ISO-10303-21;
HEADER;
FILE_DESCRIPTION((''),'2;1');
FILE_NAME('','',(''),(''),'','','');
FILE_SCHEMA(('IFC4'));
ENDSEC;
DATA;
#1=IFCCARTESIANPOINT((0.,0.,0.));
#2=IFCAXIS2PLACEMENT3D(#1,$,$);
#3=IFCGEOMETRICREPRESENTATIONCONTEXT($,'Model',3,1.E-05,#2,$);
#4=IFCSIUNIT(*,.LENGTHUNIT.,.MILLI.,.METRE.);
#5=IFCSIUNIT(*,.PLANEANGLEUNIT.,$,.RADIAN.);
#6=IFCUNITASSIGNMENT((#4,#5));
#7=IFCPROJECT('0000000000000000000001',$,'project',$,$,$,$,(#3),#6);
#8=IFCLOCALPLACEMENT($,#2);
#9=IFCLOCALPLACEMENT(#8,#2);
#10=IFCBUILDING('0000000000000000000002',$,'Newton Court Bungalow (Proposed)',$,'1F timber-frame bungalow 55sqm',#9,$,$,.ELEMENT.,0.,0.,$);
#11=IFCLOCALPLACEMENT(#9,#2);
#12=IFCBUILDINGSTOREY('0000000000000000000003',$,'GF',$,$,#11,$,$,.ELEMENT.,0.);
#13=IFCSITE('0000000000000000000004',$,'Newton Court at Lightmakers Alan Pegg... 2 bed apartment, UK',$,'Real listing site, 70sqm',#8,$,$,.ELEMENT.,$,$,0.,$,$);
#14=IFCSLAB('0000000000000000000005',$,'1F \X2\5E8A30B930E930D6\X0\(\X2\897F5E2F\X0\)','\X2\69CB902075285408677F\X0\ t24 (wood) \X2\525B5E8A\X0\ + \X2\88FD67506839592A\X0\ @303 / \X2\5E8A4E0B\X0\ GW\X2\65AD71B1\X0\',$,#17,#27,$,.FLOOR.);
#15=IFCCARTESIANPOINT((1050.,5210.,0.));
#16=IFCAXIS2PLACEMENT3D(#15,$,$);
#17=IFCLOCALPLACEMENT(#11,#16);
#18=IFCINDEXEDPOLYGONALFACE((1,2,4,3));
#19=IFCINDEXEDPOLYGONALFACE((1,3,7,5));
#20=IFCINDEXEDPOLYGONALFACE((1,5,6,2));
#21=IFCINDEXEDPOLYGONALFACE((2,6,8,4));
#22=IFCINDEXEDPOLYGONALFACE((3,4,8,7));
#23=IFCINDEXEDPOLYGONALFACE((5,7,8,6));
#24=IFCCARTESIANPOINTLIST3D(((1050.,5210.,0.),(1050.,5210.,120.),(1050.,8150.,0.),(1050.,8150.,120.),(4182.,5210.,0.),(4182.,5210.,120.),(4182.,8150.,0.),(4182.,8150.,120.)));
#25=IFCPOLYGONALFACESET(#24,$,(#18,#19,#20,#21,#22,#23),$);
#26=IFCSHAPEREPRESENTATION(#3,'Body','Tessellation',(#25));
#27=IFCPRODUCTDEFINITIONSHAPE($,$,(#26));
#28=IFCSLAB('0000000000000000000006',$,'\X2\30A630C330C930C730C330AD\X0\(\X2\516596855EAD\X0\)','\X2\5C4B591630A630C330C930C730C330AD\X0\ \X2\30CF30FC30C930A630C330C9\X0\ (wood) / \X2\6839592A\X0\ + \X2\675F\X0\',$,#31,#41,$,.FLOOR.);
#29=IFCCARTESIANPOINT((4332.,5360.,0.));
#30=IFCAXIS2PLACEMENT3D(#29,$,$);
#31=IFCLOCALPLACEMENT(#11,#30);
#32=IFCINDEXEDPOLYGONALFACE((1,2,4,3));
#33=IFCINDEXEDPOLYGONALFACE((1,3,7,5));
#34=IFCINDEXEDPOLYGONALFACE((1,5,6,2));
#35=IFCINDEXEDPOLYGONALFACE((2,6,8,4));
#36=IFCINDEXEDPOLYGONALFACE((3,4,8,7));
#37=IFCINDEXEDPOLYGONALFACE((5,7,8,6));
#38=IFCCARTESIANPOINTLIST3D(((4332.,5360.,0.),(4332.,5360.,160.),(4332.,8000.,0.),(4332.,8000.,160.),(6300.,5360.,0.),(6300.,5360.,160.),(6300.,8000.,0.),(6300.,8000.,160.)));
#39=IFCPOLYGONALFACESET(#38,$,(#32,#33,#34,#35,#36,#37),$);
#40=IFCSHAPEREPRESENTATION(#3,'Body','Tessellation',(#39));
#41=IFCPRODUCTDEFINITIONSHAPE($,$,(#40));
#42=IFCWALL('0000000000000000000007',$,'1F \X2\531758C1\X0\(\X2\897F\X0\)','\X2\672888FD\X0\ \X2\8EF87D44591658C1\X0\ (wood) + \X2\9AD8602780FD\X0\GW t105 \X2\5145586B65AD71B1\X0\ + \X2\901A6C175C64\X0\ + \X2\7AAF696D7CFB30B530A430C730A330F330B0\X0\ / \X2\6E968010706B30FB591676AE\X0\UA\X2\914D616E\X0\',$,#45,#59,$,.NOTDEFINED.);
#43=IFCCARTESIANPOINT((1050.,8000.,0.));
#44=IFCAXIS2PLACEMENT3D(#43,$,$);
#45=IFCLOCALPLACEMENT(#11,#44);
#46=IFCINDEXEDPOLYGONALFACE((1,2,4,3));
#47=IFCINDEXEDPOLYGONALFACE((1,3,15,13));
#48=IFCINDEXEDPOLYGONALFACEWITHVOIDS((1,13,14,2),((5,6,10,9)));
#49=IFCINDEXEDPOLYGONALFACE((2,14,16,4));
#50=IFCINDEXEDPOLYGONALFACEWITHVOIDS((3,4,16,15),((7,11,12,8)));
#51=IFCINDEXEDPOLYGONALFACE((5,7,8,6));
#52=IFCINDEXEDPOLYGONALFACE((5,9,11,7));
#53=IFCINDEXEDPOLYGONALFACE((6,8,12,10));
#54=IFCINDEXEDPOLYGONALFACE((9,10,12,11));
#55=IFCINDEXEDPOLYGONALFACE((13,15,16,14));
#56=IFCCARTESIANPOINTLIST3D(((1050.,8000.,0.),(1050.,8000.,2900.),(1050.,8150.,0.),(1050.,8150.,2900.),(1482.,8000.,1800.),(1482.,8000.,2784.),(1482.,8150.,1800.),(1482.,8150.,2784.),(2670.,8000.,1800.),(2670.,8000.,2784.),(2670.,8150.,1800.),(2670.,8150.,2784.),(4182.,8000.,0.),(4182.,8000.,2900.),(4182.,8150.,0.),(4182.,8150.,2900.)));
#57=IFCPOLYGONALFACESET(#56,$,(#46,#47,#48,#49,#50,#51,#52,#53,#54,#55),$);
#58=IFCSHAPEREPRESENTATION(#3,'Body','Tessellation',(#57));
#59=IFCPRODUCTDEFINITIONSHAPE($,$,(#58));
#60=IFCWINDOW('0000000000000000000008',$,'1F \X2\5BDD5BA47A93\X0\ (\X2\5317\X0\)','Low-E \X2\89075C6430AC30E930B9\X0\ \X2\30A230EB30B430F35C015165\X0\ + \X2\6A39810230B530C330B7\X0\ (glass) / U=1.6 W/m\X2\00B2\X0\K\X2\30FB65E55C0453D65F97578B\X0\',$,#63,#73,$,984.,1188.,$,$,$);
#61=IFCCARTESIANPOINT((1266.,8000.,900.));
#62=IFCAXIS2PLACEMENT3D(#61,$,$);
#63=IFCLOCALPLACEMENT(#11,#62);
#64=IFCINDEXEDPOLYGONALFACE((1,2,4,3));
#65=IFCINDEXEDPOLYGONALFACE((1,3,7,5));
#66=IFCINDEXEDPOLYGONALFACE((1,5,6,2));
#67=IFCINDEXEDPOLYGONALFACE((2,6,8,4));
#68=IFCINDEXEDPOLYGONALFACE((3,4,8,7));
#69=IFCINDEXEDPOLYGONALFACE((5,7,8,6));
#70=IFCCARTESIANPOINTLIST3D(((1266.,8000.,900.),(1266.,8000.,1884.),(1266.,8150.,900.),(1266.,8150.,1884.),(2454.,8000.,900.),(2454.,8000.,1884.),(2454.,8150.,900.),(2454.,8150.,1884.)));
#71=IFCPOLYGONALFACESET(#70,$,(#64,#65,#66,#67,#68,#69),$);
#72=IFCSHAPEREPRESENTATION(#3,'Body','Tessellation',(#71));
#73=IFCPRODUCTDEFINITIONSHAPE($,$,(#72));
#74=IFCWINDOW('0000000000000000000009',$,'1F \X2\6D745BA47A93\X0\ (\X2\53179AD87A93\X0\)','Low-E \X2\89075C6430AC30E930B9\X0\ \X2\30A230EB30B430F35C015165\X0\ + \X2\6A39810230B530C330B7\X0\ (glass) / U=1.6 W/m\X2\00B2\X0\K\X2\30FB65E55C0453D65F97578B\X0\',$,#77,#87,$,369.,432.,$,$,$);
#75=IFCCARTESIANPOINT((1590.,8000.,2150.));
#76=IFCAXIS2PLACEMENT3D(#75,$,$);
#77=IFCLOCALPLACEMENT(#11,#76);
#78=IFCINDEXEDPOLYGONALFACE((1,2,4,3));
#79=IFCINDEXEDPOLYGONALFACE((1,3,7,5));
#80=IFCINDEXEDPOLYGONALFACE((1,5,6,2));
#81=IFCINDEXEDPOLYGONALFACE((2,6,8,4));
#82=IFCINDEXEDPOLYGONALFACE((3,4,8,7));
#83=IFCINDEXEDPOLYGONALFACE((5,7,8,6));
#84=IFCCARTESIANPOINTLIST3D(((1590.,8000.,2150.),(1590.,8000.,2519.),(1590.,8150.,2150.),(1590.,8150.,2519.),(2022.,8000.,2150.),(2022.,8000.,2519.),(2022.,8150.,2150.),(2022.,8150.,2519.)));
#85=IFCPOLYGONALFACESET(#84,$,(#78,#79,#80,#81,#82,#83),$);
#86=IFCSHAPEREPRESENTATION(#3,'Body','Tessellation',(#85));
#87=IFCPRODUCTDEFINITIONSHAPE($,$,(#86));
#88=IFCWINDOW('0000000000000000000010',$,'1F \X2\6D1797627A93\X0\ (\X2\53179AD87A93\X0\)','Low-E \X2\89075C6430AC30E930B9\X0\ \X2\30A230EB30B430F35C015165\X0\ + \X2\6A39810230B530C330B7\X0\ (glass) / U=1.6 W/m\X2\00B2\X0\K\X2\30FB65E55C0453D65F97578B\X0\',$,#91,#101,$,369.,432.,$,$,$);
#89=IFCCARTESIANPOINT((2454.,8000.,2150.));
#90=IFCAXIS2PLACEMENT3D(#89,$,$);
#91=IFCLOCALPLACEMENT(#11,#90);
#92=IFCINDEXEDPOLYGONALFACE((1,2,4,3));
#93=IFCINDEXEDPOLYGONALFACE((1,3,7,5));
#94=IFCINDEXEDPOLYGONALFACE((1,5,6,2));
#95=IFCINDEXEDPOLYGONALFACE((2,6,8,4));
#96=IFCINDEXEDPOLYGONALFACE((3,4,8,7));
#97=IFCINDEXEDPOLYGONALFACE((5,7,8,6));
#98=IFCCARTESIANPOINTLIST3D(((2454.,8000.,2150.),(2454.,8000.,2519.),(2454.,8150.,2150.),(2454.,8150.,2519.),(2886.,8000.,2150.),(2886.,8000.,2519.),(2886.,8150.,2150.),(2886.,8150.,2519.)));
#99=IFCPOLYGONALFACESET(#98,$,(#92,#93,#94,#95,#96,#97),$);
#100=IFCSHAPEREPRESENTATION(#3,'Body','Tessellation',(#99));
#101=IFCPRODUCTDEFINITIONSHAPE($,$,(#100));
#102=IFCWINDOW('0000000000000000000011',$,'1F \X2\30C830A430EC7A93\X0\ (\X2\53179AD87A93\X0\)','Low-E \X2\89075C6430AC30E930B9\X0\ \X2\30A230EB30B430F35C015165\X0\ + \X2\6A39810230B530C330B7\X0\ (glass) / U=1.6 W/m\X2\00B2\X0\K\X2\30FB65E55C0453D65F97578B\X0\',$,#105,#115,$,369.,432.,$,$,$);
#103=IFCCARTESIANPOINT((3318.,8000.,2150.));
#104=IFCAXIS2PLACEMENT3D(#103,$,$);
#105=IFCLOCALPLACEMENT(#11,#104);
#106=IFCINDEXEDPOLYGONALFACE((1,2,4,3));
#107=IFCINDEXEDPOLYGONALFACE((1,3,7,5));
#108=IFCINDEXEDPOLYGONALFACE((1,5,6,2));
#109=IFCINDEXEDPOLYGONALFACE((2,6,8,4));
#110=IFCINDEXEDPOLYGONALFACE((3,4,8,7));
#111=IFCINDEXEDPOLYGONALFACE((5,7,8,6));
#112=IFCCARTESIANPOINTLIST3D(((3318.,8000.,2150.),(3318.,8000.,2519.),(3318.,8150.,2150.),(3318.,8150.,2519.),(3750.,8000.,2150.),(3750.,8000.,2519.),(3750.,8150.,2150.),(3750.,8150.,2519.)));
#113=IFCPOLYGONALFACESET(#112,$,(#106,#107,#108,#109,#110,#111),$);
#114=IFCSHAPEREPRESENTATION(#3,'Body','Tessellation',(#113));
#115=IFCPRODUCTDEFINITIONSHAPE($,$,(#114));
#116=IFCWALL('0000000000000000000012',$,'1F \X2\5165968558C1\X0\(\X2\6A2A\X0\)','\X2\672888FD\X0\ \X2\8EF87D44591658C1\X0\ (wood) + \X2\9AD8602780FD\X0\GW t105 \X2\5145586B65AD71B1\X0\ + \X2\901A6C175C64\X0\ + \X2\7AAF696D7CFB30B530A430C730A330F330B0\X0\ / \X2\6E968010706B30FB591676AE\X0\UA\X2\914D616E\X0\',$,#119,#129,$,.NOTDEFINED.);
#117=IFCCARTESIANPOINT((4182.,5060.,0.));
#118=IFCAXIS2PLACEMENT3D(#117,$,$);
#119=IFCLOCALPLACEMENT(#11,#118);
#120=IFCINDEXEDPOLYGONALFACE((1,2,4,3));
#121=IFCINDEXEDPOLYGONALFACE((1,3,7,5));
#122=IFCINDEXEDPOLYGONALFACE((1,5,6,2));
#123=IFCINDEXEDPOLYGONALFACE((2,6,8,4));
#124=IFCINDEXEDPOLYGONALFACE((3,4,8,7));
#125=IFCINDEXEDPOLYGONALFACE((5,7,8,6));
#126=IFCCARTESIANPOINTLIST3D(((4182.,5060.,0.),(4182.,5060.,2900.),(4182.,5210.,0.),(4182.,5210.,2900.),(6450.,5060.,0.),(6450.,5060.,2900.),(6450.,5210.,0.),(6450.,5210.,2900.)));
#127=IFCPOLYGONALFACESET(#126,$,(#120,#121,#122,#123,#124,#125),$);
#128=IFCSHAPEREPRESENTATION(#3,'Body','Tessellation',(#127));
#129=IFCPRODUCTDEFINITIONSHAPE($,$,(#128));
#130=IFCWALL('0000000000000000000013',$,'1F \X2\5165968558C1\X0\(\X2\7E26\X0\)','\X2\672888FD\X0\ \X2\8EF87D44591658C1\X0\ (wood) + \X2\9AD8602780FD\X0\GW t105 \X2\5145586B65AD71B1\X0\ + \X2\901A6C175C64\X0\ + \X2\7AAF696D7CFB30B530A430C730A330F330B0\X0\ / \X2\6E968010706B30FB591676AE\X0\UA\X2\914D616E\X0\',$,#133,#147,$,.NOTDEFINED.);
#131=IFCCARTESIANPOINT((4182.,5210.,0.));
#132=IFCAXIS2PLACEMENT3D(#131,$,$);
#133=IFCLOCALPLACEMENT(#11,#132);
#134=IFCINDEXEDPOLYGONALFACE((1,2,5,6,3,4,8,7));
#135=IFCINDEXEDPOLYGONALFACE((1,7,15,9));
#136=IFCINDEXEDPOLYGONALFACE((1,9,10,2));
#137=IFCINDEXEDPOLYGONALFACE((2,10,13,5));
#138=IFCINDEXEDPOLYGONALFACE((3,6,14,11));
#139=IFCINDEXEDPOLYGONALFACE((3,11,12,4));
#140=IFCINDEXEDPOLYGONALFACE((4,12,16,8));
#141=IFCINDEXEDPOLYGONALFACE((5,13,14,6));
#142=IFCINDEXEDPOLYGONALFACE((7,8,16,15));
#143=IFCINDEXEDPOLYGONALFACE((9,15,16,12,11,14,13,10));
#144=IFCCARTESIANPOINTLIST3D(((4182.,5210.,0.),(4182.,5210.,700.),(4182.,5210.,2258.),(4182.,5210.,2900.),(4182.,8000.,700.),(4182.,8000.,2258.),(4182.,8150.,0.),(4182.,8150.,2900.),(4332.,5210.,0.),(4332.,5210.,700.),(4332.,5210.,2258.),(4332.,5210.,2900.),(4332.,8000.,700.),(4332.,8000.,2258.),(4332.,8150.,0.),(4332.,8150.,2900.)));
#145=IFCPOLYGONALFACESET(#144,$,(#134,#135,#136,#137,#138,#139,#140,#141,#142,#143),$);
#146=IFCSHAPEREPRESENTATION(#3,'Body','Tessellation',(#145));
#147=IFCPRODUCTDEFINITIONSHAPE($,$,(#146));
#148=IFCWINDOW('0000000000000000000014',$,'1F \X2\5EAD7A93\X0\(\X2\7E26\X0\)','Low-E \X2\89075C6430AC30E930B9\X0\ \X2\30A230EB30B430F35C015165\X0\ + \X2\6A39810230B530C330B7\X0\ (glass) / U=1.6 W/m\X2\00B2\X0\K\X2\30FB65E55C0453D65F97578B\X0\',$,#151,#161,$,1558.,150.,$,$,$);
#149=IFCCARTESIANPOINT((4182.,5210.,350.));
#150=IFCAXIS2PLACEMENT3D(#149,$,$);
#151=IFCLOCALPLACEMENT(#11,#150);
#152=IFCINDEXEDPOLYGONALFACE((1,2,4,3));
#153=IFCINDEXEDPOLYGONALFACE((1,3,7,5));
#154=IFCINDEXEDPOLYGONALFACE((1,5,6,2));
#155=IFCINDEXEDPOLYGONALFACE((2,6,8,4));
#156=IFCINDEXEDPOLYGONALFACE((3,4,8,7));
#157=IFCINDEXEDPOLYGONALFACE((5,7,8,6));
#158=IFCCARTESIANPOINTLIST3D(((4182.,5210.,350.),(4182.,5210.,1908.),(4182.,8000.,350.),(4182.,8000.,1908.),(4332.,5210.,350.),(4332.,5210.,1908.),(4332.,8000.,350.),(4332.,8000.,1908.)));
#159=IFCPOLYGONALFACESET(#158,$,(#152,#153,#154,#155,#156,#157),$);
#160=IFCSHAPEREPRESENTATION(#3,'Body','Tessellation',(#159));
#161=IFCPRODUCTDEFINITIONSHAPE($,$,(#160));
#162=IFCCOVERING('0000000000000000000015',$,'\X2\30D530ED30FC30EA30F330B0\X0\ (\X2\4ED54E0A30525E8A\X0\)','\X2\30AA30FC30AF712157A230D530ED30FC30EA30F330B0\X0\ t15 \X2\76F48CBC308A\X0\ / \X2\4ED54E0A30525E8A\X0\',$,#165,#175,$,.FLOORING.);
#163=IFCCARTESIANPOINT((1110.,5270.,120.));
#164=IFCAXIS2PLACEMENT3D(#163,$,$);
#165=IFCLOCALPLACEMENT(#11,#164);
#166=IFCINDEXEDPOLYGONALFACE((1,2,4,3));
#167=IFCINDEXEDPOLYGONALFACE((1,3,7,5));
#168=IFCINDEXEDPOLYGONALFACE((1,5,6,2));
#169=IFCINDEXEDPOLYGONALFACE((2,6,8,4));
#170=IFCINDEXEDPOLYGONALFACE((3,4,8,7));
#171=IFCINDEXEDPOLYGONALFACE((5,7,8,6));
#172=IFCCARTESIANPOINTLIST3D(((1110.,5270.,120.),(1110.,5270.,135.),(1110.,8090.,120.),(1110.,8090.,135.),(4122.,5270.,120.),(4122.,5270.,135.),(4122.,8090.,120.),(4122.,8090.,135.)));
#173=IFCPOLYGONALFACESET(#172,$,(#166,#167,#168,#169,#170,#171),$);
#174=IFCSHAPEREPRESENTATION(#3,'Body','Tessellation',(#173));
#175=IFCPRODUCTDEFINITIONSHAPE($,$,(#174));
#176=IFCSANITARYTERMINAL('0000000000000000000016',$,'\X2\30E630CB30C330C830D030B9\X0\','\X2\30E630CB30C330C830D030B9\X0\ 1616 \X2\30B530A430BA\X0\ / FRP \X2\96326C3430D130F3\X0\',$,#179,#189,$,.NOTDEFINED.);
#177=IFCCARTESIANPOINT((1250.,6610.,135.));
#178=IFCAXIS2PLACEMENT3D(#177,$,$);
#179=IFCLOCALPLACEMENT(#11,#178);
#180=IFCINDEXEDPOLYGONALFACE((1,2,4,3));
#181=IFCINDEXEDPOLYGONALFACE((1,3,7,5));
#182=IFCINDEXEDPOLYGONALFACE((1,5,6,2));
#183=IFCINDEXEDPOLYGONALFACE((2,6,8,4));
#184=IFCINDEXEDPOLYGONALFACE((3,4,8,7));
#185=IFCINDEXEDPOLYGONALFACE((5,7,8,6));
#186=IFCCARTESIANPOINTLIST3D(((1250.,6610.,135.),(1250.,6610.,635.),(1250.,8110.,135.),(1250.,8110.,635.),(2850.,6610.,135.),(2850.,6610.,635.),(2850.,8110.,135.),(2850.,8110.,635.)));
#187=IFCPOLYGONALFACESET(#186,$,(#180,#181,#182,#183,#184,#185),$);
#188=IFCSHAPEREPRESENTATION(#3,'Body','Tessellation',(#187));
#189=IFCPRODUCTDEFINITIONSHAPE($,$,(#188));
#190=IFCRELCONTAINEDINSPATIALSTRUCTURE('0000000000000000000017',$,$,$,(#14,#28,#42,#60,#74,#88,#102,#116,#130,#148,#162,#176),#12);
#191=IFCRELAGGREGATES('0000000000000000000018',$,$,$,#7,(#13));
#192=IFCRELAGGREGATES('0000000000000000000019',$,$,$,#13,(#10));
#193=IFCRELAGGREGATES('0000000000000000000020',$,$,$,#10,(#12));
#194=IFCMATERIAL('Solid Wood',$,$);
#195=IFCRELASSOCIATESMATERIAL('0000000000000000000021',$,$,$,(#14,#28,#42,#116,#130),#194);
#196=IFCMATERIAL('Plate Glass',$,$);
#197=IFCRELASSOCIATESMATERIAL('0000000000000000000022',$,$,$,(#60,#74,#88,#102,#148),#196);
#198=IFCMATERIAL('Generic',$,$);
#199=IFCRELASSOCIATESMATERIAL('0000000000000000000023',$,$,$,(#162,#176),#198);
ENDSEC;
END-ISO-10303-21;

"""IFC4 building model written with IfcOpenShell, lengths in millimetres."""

from ifc_helpers import new_model, si_unit, frame, frame_2d, origin, place, context, project, spatial, rectangle, extrude, material, element, fill, save


model = new_model("IFC4")

# Units and contexts
model_context = context("Model", 3, precision=1e-05, world=origin())
ifc_project = project(units=[si_unit("LENGTHUNIT", "METRE", prefix="MILLI"), si_unit("PLANEANGLEUNIT", "RADIAN")], contexts=[model_context])

# Site, building, storey
site_placement = place(None, origin())
site = spatial("IfcSite", under=ifc_project, at=site_placement, Name="Newton Court at Lightmakers Alan Pegg... 2 bed apartment, UK", ObjectType="Real listing site, 70sqm", CompositionType="ELEMENT", RefElevation=0.0)
building_placement = place(site_placement, origin())
building = spatial("IfcBuilding", under=site, at=building_placement, Name="Newton Court Bungalow (Proposed)", ObjectType="1F timber-frame bungalow 55sqm", CompositionType="ELEMENT", ElevationOfRefHeight=0.0, ElevationOfTerrain=0.0)
storey_placement = place(building_placement, origin())
storey = spatial("IfcBuildingStorey", under=building, at=storey_placement, Name="GF", CompositionType="ELEMENT", Elevation=0.0)

# Slabs
ifc_material_1 = material(Name="Solid Wood")
slab_1_placement = place(storey_placement, frame((1050.0, 5210.0, 0.0)))
element("IfcSlab", 1, at=slab_1_placement, inside=storey, material=ifc_material_1, Name="1F 床スラブ(西帯)", Description="構造用合板 t24 (wood) 剛床 + 製材根太 @303 / 床下 GW断熱", PredefinedType="FLOOR", context=model_context, shape_type="SweptSolid", body=[
    extrude(rectangle(XDim=3132.0, YDim=2940.0, at=frame_2d((1566.0, 1470.0))), frame((1050.0, 5210.0, 0.0)), (0.0, 0.0, 1.0), 120.0),
])
slab_2_placement = place(storey_placement, frame((4332.0, 5360.0, 0.0)))
element("IfcSlab", 2, at=slab_2_placement, inside=storey, material=ifc_material_1, Name="ウッドデッキ(入隅庭)", Description="屋外ウッドデッキ ハードウッド (wood) / 根太 + 束", PredefinedType="FLOOR", context=model_context, shape_type="SweptSolid", body=[
    extrude(rectangle(XDim=1968.0, YDim=2640.0, at=frame_2d((984.0, 1320.0))), frame((4332.0, 5360.0, 0.0)), (0.0, 0.0, 1.0), 160.0),
])

# Wall, openings, windows
wall_1_placement = place(storey_placement, frame((1050.0, 8000.0, 0.0)))
wall_1 = element("IfcWall", 3, at=wall_1_placement, inside=storey, material=ifc_material_1, Name="1F 北壁(西)", Description="木製 軸組外壁 (wood) + 高性能GW t105 充填断熱 + 通気層 + 窯業系サイディング / 準耐火・外皮UA配慮", PredefinedType="NOTDEFINED", context=model_context, shape_type="SweptSolid", body=[
    extrude(rectangle(XDim=3132.0, YDim=150.0, at=frame_2d((1566.0, 75.0))), frame((1050.0, 8000.0, 0.0)), (0.0, 0.0, 1.0), 2900.0),
])
opening_1_placement = place(storey_placement, frame((1266.0, 8000.0, 900.0)))
opening_1 = element("IfcOpeningElement", 4, at=opening_1_placement, cuts=wall_1, PredefinedType="NOTDEFINED", context=model_context, shape_type="SweptSolid", body=[
    extrude(rectangle(XDim=1188.0, YDim=150.0, at=frame_2d((594.0, 75.0))), frame((1266.0, 8000.0, 900.0)), (0.0, 0.0, 1.0), 984.0),
])
opening_2_placement = place(storey_placement, frame((1590.0, 8000.0, 2150.0)))
opening_2 = element("IfcOpeningElement", 5, at=opening_2_placement, cuts=wall_1, PredefinedType="NOTDEFINED", context=model_context, shape_type="SweptSolid", body=[
    extrude(rectangle(XDim=432.0, YDim=150.0, at=frame_2d((216.0, 75.0))), frame((1590.0, 8000.0, 2150.0)), (0.0, 0.0, 1.0), 369.0),
])
opening_3_placement = place(storey_placement, frame((2454.0, 8000.0, 2150.0)))
opening_3 = element("IfcOpeningElement", 6, at=opening_3_placement, cuts=wall_1, PredefinedType="NOTDEFINED", context=model_context, shape_type="SweptSolid", body=[
    extrude(rectangle(XDim=432.0, YDim=150.0, at=frame_2d((216.0, 75.0))), frame((2454.0, 8000.0, 2150.0)), (0.0, 0.0, 1.0), 369.0),
])
opening_4_placement = place(storey_placement, frame((3318.0, 8000.0, 2150.0)))
opening_4 = element("IfcOpeningElement", 7, at=opening_4_placement, cuts=wall_1, PredefinedType="NOTDEFINED", context=model_context, shape_type="SweptSolid", body=[
    extrude(rectangle(XDim=432.0, YDim=150.0, at=frame_2d((216.0, 75.0))), frame((3318.0, 8000.0, 2150.0)), (0.0, 0.0, 1.0), 369.0),
])
ifc_material_2 = material(Name="Plate Glass")
window_1_placement = place(storey_placement, frame((1266.0, 8000.0, 900.0)))
window_1 = element("IfcWindow", 8, at=window_1_placement, inside=storey, material=ifc_material_2, Name="1F 寝室窓 (北)", Description="Low-E 複層ガラス アルゴン封入 + 樹脂サッシ (glass) / U=1.6 W/m²K・日射取得型", OverallHeight=984.0, OverallWidth=1188.0, context=model_context, shape_type="SweptSolid", body=[
    extrude(rectangle(XDim=1188.0, YDim=150.0, at=frame_2d((594.0, 75.0))), frame((1266.0, 8000.0, 900.0)), (0.0, 0.0, 1.0), 984.0),
])
fill(opening_1, window_1)
window_2_placement = place(storey_placement, frame((1590.0, 8000.0, 2150.0)))
window_2 = element("IfcWindow", 9, at=window_2_placement, inside=storey, material=ifc_material_2, Name="1F 浴室窓 (北高窓)", Description="Low-E 複層ガラス アルゴン封入 + 樹脂サッシ (glass) / U=1.6 W/m²K・日射取得型", OverallHeight=369.0, OverallWidth=432.0, context=model_context, shape_type="SweptSolid", body=[
    extrude(rectangle(XDim=432.0, YDim=150.0, at=frame_2d((216.0, 75.0))), frame((1590.0, 8000.0, 2150.0)), (0.0, 0.0, 1.0), 369.0),
])
fill(opening_2, window_2)
window_3_placement = place(storey_placement, frame((2454.0, 8000.0, 2150.0)))
window_3 = element("IfcWindow", 10, at=window_3_placement, inside=storey, material=ifc_material_2, Name="1F 洗面窓 (北高窓)", Description="Low-E 複層ガラス アルゴン封入 + 樹脂サッシ (glass) / U=1.6 W/m²K・日射取得型", OverallHeight=369.0, OverallWidth=432.0, context=model_context, shape_type="SweptSolid", body=[
    extrude(rectangle(XDim=432.0, YDim=150.0, at=frame_2d((216.0, 75.0))), frame((2454.0, 8000.0, 2150.0)), (0.0, 0.0, 1.0), 369.0),
])
fill(opening_3, window_3)
window_4_placement = place(storey_placement, frame((3318.0, 8000.0, 2150.0)))
window_4 = element("IfcWindow", 11, at=window_4_placement, inside=storey, material=ifc_material_2, Name="1F トイレ窓 (北高窓)", Description="Low-E 複層ガラス アルゴン封入 + 樹脂サッシ (glass) / U=1.6 W/m²K・日射取得型", OverallHeight=369.0, OverallWidth=432.0, context=model_context, shape_type="SweptSolid", body=[
    extrude(rectangle(XDim=432.0, YDim=150.0, at=frame_2d((216.0, 75.0))), frame((3318.0, 8000.0, 2150.0)), (0.0, 0.0, 1.0), 369.0),
])
fill(opening_4, window_4)

# Wall
wall_2_placement = place(storey_placement, frame((4182.0, 5060.0, 0.0)))
element("IfcWall", 12, at=wall_2_placement, inside=storey, material=ifc_material_1, Name="1F 入隅壁(横)", Description="木製 軸組外壁 (wood) + 高性能GW t105 充填断熱 + 通気層 + 窯業系サイディング / 準耐火・外皮UA配慮", PredefinedType="NOTDEFINED", context=model_context, shape_type="SweptSolid", body=[
    extrude(rectangle(XDim=2268.0, YDim=150.0, at=frame_2d((1134.0, 75.0))), frame((4182.0, 5060.0, 0.0)), (0.0, 0.0, 1.0), 2900.0),
])

# Wall, opening, window
wall_3_placement = place(storey_placement, frame((4182.0, 5210.0, 0.0)))
wall_3 = element("IfcWall", 13, at=wall_3_placement, inside=storey, material=ifc_material_1, Name="1F 入隅壁(縦)", Description="木製 軸組外壁 (wood) + 高性能GW t105 充填断熱 + 通気層 + 窯業系サイディング / 準耐火・外皮UA配慮", PredefinedType="NOTDEFINED", context=model_context, shape_type="SweptSolid", body=[
    extrude(rectangle(XDim=150.0, YDim=2940.0, at=frame_2d((75.0, 1470.0))), frame((4182.0, 5210.0, 0.0)), (0.0, 0.0, 1.0), 2900.0),
])
opening_5_placement = place(storey_placement, frame((4182.0, 5210.0, 350.0)))
opening_5 = element("IfcOpeningElement", 14, at=opening_5_placement, cuts=wall_3, PredefinedType="NOTDEFINED", context=model_context, shape_type="SweptSolid", body=[
    extrude(rectangle(XDim=150.0, YDim=2790.0, at=frame_2d((75.0, 1395.0))), frame((4182.0, 5210.0, 350.0)), (0.0, 0.0, 1.0), 1558.0),
])
window_5_placement = place(storey_placement, frame((4182.0, 5210.0, 350.0)))
window_5 = element("IfcWindow", 15, at=window_5_placement, inside=storey, material=ifc_material_2, Name="1F 庭窓(縦)", Description="Low-E 複層ガラス アルゴン封入 + 樹脂サッシ (glass) / U=1.6 W/m²K・日射取得型", OverallHeight=1558.0, OverallWidth=150.0, context=model_context, shape_type="SweptSolid", body=[
    extrude(rectangle(XDim=150.0, YDim=2790.0, at=frame_2d((75.0, 1395.0))), frame((4182.0, 5210.0, 350.0)), (0.0, 0.0, 1.0), 1558.0),
])
fill(opening_5, window_5)

# Covering
ifc_material_3 = material(Name="Generic")
covering_placement = place(storey_placement, frame((1110.0, 5270.0, 120.0)))
element("IfcCovering", 16, at=covering_placement, inside=storey, material=ifc_material_3, Name="フローリング (仕上げ床)", Description="オーク無垢フローリング t15 直貼り / 仕上げ床", PredefinedType="FLOORING", context=model_context, shape_type="SweptSolid", body=[
    extrude(rectangle(XDim=3012.0, YDim=2820.0, at=frame_2d((1506.0, 1410.0))), frame((1110.0, 5270.0, 120.0)), (0.0, 0.0, 1.0), 15.0),
])

# Sanitary terminal
sanitary_terminal_1_placement = place(storey_placement, frame((1250.0, 6610.0, 135.0)))
element("IfcSanitaryTerminal", 17, at=sanitary_terminal_1_placement, inside=storey, material=ifc_material_3, Name="ユニットバス", Description="ユニットバス 1616 サイズ / FRP 防水パン", PredefinedType="NOTDEFINED", context=model_context, shape_type="SweptSolid", body=[
    extrude(rectangle(XDim=1600.0, YDim=1500.0, at=frame_2d((800.0, 750.0))), frame((1250.0, 6610.0, 135.0)), (0.0, 0.0, 1.0), 500.0),
])

save(model, "model.ifc")
